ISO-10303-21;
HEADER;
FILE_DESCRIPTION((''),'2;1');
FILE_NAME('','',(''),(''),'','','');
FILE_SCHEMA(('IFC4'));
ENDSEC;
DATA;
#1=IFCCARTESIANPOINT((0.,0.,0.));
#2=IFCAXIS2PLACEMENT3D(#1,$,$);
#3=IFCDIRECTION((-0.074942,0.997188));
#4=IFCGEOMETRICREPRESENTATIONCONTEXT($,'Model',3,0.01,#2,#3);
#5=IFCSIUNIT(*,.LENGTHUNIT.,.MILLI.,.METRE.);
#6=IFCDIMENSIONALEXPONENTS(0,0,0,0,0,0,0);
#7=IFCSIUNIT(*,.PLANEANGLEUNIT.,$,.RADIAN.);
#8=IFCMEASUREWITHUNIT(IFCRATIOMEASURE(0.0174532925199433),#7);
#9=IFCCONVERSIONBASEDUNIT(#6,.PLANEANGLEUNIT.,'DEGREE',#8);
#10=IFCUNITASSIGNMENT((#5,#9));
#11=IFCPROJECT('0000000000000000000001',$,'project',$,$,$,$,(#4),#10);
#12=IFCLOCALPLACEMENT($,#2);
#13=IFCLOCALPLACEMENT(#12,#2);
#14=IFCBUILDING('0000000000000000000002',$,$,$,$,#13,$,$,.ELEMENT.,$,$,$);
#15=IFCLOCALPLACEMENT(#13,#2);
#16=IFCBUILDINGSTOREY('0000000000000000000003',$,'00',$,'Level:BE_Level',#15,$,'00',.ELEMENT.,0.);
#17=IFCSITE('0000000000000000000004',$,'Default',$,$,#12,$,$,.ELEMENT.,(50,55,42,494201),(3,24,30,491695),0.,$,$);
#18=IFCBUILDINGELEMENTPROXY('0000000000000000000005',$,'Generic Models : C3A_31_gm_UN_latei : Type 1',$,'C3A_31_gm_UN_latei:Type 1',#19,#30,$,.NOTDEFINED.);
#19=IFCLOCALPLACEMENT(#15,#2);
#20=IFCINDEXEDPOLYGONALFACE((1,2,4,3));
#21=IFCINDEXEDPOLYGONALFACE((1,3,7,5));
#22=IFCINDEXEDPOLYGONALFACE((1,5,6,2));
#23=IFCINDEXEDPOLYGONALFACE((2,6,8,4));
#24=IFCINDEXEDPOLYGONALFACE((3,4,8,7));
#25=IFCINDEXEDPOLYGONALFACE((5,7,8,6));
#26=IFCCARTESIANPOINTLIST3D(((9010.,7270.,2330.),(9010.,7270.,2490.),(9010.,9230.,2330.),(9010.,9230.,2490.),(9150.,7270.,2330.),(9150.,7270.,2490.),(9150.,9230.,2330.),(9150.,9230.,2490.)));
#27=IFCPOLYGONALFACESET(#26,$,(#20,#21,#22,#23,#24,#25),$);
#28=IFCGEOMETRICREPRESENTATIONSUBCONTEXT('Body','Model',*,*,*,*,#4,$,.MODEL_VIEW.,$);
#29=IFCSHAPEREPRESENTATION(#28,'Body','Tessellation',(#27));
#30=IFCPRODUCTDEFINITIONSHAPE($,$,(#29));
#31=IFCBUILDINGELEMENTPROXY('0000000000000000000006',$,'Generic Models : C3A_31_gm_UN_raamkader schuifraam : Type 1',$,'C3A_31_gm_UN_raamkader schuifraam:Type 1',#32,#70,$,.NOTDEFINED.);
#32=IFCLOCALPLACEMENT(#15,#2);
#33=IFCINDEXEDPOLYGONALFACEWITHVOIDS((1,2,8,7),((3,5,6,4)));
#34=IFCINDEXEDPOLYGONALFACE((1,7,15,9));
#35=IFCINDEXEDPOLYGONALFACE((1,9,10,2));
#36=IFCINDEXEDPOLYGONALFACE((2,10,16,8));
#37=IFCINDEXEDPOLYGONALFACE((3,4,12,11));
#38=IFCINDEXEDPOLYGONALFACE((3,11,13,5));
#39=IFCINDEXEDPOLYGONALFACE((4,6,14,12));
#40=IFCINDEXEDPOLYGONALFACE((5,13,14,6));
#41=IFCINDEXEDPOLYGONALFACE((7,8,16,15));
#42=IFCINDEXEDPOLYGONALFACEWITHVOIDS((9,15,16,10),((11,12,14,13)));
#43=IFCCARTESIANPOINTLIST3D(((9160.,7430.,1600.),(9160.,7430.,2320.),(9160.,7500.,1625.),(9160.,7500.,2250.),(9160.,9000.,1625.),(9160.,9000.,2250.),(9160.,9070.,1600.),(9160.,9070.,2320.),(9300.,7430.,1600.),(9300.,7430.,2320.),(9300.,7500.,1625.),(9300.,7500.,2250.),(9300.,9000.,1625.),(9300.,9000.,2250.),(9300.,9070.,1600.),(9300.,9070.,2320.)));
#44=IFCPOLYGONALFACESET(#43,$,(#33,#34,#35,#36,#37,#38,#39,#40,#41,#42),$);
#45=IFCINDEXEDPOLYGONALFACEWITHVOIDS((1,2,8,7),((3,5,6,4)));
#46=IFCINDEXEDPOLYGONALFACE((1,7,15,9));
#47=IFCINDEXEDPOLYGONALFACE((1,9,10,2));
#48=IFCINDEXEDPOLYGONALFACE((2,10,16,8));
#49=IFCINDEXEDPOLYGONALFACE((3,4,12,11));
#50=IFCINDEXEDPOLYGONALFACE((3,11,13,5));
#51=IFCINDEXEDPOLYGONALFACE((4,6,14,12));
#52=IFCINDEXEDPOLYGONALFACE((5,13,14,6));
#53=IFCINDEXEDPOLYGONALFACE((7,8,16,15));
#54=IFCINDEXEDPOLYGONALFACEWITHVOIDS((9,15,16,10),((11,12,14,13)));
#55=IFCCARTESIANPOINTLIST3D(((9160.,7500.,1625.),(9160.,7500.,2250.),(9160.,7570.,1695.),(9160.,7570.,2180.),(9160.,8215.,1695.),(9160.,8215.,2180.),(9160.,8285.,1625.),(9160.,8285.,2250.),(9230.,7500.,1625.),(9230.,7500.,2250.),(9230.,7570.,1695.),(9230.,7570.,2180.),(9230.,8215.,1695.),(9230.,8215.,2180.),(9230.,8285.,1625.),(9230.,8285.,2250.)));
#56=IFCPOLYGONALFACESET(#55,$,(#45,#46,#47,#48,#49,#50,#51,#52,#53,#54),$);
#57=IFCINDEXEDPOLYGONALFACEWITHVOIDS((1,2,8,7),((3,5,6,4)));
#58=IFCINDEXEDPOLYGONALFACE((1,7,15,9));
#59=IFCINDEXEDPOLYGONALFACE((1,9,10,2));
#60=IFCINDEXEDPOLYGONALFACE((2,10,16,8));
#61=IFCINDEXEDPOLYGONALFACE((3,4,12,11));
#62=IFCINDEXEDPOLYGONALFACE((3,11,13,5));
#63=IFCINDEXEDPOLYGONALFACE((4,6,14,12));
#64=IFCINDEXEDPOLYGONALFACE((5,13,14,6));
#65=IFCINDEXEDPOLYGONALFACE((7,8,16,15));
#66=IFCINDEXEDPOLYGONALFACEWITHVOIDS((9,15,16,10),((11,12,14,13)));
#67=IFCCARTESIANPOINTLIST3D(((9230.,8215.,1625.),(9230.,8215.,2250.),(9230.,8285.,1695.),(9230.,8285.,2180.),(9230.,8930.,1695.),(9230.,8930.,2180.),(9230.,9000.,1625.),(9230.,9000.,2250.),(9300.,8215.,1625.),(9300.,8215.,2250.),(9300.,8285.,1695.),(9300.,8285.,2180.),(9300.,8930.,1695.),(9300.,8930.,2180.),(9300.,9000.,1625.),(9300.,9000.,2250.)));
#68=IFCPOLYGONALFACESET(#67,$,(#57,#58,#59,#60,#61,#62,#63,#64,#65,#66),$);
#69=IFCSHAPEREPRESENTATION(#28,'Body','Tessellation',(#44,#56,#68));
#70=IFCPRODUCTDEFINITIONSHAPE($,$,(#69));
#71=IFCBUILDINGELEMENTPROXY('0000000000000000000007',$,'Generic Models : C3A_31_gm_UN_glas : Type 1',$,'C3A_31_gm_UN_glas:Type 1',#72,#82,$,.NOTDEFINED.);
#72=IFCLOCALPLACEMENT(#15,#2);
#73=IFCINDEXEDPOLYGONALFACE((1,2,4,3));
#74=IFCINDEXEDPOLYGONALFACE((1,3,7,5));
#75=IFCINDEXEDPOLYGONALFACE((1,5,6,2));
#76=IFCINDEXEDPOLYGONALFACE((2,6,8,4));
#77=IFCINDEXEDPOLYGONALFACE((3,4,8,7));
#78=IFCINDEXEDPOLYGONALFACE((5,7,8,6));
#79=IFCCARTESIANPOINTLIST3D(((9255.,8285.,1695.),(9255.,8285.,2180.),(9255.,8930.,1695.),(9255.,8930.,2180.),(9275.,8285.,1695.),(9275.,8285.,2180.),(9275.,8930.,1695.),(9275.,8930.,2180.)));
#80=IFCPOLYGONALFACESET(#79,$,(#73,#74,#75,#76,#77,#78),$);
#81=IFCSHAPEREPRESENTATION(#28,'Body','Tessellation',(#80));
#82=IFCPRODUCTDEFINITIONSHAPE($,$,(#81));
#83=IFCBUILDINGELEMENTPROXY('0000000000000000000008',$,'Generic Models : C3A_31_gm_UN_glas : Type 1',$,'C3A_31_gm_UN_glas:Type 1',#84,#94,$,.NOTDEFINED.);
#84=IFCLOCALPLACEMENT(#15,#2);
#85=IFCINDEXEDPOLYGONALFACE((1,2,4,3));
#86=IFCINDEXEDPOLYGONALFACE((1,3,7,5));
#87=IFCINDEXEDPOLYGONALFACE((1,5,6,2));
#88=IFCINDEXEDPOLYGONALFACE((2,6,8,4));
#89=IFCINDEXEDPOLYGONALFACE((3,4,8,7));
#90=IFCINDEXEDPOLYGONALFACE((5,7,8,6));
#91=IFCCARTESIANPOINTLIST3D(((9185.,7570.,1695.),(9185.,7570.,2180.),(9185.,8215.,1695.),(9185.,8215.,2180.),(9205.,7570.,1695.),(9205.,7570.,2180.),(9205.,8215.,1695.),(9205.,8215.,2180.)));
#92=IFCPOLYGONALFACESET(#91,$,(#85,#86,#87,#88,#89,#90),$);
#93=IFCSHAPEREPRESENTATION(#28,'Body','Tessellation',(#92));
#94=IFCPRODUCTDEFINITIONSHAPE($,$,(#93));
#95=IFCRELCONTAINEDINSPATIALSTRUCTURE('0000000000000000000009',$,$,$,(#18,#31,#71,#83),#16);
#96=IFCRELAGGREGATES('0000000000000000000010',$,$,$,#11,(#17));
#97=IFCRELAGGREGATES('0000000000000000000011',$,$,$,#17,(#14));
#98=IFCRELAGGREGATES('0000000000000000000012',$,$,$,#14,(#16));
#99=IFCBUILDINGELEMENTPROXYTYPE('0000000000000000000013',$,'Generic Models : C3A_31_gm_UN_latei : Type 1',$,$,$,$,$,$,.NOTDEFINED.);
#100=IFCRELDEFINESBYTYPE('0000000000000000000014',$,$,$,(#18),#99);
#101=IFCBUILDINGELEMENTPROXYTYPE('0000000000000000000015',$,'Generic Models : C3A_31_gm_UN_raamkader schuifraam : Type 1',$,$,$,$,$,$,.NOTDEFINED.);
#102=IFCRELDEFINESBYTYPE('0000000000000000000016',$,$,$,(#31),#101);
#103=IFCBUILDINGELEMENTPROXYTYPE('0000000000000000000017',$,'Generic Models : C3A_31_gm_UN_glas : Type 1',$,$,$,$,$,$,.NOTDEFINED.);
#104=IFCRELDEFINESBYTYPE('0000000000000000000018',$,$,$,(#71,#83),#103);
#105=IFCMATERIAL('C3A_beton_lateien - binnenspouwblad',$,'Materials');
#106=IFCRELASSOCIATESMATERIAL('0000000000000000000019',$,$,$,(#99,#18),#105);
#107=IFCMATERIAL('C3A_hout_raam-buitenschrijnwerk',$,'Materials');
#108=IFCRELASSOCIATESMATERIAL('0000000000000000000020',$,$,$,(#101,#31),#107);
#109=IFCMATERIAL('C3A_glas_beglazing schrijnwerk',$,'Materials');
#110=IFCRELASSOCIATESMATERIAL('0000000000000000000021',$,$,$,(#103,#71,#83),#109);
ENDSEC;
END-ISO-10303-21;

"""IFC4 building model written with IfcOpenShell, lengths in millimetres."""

from ifc_helpers import new_model, entity, si_unit, converted_unit, direction, frame, origin, origin_2d_with_axis, place, context, subcontext, project, spatial, polyline, rectangle, outline, extrude, source, transform, mapped, material, type_object, type_shapes, element, save


model = new_model("IFC4")

# Units and contexts
model_context = context("Model", 3, precision=0.01, world=origin(), true_north=direction((-0.074942, 0.997188)))
body_context = subcontext(model_context, "Body", "Model", "MODEL_VIEW")
ifc_project = project(units=[si_unit("LENGTHUNIT", "METRE", prefix="MILLI"), converted_unit("PLANEANGLEUNIT", "DEGREE", entity("IfcRatioMeasure", 0.0174532925199433), si_unit("PLANEANGLEUNIT", "RADIAN"), dimensions=[0, 0, 0, 0, 0, 0, 0])], contexts=[model_context])

# Site, building, storey
site_placement = place(None, origin())
site = spatial("IfcSite", under=ifc_project, at=site_placement, Name="Default", CompositionType="ELEMENT", RefLatitude=(50, 55, 42, 494201), RefLongitude=(3, 24, 30, 491695), RefElevation=0.0)
building_placement = place(site_placement, origin())
building = spatial("IfcBuilding", under=site, at=building_placement, CompositionType="ELEMENT")
storey_placement = place(building_placement, frame((0.0, 0.0, 0.0)))
storey = spatial("IfcBuildingStorey", under=building, at=storey_placement, Name="00", ObjectType="Level:BE_Level", LongName="00", CompositionType="ELEMENT", Elevation=0.0)

# Building element proxies
ifc_material_1 = material(Name="C3A_beton_lateien - binnenspouwblad", Category="Materials")
ifc_material_2 = material(Name="C3A_hout_raam-buitenschrijnwerk", Category="Materials")
ifc_material_3 = material(Name="C3A_glas_beglazing schrijnwerk", Category="Materials")
building_element_proxy_type_1 = type_object("IfcBuildingElementProxyType", Name="Generic Models : C3A_31_gm_UN_latei : Type 1", PredefinedType="NOTDEFINED", material=ifc_material_1)
shared_shape_1 = source(origin(), body_context, "Body", "SweptSolid", [
    extrude(rectangle(XDim=1960.0, YDim=140.0, at=origin_2d_with_axis()), frame((0.0, 70.0, 0.0), z_axis=(0.0, 0.0, 1.0), x_axis=(-1.0, 0.0, 0.0)), (0.0, 0.0, 1.0), 160.0),
])
type_shapes(building_element_proxy_type_1, [shared_shape_1])
proxy_1_placement = place(storey_placement, frame((9010.0, 8250.0, 2330.0), z_axis=(0.0, 0.0, 1.0), x_axis=(0.0, -1.0, 0.0)))
element("IfcBuildingElementProxy", 1, at=proxy_1_placement, inside=storey, type_object=building_element_proxy_type_1, material=ifc_material_1, Name="Generic Models : C3A_31_gm_UN_latei : Type 1", ObjectType="C3A_31_gm_UN_latei:Type 1", PredefinedType="NOTDEFINED", context=body_context, shape_type="MappedRepresentation", body=[
    mapped(shared_shape_1, transform((0.0, 0.0, 0.0), scale=1.0)),
])
building_element_proxy_type_2 = type_object("IfcBuildingElementProxyType", Name="Generic Models : C3A_31_gm_UN_raamkader schuifraam : Type 1", PredefinedType="NOTDEFINED", material=ifc_material_2)
shared_shape_2 = source(origin(), body_context, "Body", "SweptSolid", [
    extrude(outline(polyline([(-360.0, -820.0), (360.0, -820.0), (360.0, 820.0), (-360.0, 820.0), (-360.0, -820.0)]), holes=[polyline([(290.0, 750.0), (290.0, -750.0), (-335.0, -750.0), (-335.0, 750.0), (290.0, 750.0)])]), frame((820.0, 0.0, 360.0), z_axis=(0.0, 1.0, 0.0), x_axis=(0.0, 0.0, 1.0)), (0.0, 0.0, 1.0), 140.0),
    extrude(outline(polyline([(-312.5, -392.5), (312.5, -392.5), (312.5, 392.5), (-312.5, 392.5), (-312.5, -392.5)]), holes=[polyline([(242.5, -322.5), (-242.5, -322.5), (-242.5, 322.5), (242.5, 322.5), (242.5, -322.5)])]), frame((1177.5, 0.0, 337.5), z_axis=(0.0, 1.0, 0.0), x_axis=(0.0, 0.0, -1.0)), (0.0, 0.0, 1.0), 70.0),
    extrude(outline(polyline([(-392.5, -312.5), (392.5, -312.5), (392.5, 312.5), (-392.5, 312.5), (-392.5, -312.5)]), holes=[polyline([(322.5, -242.5), (-322.5, -242.5), (-322.5, 242.5), (322.5, 242.5), (322.5, -242.5)])]), frame((462.5, 70.0, 337.5), z_axis=(0.0, 1.0, 0.0), x_axis=(-1.0, 0.0, 0.0)), (0.0, 0.0, 1.0), 70.0),
])
type_shapes(building_element_proxy_type_2, [shared_shape_2])
proxy_2_placement = place(storey_placement, frame((9160.0, 9070.0, 1600.0), z_axis=(0.0, 0.0, 1.0), x_axis=(0.0, -1.0, 0.0)))
element("IfcBuildingElementProxy", 2, at=proxy_2_placement, inside=storey, type_object=building_element_proxy_type_2, material=ifc_material_2, Name="Generic Models : C3A_31_gm_UN_raamkader schuifraam : Type 1", ObjectType="C3A_31_gm_UN_raamkader schuifraam:Type 1", PredefinedType="NOTDEFINED", context=body_context, shape_type="MappedRepresentation", body=[
    mapped(shared_shape_2, transform((0.0, 0.0, 0.0), scale=1.0)),
])
building_element_proxy_type_3 = type_object("IfcBuildingElementProxyType", Name="Generic Models : C3A_31_gm_UN_glas : Type 1", PredefinedType="NOTDEFINED", material=ifc_material_3)
shared_shape_3 = source(origin(), body_context, "Body", "SweptSolid", [
    extrude(rectangle(XDim=20.0, YDim=645.0, at=origin_2d_with_axis()), frame((322.5, 10.0, 0.0), z_axis=(0.0, 0.0, 1.0), x_axis=(0.0, 1.0, 0.0)), (0.0, 0.0, 1.0), 485.0),
])
type_shapes(building_element_proxy_type_3, [shared_shape_3])
for number, where, z_axis, x_axis, name in (
    (3, (9275.0, 8285.0, 1695.0), (0.0, 0.0, 1.0), (0.0, 1.0, 0.0), "Generic Models : C3A_31_gm_UN_glas : Type 1"),
    (4, (9205.0, 7570.0, 1695.0), (0.0, 0.0, 1.0), (0.0, 1.0, 0.0), "Generic Models : C3A_31_gm_UN_glas : Type 1"),
):
    element("IfcBuildingElementProxy", number, at=place(storey_placement, frame(where, z_axis=z_axis, x_axis=x_axis)), inside=storey, type_object=building_element_proxy_type_3, material=ifc_material_3, Name=name, ObjectType="C3A_31_gm_UN_glas:Type 1", PredefinedType="NOTDEFINED", context=body_context, shape_type="MappedRepresentation", body=[
        mapped(shared_shape_3, transform((0.0, 0.0, 0.0), scale=1.0)),
    ])

save(model, "model.ifc")
